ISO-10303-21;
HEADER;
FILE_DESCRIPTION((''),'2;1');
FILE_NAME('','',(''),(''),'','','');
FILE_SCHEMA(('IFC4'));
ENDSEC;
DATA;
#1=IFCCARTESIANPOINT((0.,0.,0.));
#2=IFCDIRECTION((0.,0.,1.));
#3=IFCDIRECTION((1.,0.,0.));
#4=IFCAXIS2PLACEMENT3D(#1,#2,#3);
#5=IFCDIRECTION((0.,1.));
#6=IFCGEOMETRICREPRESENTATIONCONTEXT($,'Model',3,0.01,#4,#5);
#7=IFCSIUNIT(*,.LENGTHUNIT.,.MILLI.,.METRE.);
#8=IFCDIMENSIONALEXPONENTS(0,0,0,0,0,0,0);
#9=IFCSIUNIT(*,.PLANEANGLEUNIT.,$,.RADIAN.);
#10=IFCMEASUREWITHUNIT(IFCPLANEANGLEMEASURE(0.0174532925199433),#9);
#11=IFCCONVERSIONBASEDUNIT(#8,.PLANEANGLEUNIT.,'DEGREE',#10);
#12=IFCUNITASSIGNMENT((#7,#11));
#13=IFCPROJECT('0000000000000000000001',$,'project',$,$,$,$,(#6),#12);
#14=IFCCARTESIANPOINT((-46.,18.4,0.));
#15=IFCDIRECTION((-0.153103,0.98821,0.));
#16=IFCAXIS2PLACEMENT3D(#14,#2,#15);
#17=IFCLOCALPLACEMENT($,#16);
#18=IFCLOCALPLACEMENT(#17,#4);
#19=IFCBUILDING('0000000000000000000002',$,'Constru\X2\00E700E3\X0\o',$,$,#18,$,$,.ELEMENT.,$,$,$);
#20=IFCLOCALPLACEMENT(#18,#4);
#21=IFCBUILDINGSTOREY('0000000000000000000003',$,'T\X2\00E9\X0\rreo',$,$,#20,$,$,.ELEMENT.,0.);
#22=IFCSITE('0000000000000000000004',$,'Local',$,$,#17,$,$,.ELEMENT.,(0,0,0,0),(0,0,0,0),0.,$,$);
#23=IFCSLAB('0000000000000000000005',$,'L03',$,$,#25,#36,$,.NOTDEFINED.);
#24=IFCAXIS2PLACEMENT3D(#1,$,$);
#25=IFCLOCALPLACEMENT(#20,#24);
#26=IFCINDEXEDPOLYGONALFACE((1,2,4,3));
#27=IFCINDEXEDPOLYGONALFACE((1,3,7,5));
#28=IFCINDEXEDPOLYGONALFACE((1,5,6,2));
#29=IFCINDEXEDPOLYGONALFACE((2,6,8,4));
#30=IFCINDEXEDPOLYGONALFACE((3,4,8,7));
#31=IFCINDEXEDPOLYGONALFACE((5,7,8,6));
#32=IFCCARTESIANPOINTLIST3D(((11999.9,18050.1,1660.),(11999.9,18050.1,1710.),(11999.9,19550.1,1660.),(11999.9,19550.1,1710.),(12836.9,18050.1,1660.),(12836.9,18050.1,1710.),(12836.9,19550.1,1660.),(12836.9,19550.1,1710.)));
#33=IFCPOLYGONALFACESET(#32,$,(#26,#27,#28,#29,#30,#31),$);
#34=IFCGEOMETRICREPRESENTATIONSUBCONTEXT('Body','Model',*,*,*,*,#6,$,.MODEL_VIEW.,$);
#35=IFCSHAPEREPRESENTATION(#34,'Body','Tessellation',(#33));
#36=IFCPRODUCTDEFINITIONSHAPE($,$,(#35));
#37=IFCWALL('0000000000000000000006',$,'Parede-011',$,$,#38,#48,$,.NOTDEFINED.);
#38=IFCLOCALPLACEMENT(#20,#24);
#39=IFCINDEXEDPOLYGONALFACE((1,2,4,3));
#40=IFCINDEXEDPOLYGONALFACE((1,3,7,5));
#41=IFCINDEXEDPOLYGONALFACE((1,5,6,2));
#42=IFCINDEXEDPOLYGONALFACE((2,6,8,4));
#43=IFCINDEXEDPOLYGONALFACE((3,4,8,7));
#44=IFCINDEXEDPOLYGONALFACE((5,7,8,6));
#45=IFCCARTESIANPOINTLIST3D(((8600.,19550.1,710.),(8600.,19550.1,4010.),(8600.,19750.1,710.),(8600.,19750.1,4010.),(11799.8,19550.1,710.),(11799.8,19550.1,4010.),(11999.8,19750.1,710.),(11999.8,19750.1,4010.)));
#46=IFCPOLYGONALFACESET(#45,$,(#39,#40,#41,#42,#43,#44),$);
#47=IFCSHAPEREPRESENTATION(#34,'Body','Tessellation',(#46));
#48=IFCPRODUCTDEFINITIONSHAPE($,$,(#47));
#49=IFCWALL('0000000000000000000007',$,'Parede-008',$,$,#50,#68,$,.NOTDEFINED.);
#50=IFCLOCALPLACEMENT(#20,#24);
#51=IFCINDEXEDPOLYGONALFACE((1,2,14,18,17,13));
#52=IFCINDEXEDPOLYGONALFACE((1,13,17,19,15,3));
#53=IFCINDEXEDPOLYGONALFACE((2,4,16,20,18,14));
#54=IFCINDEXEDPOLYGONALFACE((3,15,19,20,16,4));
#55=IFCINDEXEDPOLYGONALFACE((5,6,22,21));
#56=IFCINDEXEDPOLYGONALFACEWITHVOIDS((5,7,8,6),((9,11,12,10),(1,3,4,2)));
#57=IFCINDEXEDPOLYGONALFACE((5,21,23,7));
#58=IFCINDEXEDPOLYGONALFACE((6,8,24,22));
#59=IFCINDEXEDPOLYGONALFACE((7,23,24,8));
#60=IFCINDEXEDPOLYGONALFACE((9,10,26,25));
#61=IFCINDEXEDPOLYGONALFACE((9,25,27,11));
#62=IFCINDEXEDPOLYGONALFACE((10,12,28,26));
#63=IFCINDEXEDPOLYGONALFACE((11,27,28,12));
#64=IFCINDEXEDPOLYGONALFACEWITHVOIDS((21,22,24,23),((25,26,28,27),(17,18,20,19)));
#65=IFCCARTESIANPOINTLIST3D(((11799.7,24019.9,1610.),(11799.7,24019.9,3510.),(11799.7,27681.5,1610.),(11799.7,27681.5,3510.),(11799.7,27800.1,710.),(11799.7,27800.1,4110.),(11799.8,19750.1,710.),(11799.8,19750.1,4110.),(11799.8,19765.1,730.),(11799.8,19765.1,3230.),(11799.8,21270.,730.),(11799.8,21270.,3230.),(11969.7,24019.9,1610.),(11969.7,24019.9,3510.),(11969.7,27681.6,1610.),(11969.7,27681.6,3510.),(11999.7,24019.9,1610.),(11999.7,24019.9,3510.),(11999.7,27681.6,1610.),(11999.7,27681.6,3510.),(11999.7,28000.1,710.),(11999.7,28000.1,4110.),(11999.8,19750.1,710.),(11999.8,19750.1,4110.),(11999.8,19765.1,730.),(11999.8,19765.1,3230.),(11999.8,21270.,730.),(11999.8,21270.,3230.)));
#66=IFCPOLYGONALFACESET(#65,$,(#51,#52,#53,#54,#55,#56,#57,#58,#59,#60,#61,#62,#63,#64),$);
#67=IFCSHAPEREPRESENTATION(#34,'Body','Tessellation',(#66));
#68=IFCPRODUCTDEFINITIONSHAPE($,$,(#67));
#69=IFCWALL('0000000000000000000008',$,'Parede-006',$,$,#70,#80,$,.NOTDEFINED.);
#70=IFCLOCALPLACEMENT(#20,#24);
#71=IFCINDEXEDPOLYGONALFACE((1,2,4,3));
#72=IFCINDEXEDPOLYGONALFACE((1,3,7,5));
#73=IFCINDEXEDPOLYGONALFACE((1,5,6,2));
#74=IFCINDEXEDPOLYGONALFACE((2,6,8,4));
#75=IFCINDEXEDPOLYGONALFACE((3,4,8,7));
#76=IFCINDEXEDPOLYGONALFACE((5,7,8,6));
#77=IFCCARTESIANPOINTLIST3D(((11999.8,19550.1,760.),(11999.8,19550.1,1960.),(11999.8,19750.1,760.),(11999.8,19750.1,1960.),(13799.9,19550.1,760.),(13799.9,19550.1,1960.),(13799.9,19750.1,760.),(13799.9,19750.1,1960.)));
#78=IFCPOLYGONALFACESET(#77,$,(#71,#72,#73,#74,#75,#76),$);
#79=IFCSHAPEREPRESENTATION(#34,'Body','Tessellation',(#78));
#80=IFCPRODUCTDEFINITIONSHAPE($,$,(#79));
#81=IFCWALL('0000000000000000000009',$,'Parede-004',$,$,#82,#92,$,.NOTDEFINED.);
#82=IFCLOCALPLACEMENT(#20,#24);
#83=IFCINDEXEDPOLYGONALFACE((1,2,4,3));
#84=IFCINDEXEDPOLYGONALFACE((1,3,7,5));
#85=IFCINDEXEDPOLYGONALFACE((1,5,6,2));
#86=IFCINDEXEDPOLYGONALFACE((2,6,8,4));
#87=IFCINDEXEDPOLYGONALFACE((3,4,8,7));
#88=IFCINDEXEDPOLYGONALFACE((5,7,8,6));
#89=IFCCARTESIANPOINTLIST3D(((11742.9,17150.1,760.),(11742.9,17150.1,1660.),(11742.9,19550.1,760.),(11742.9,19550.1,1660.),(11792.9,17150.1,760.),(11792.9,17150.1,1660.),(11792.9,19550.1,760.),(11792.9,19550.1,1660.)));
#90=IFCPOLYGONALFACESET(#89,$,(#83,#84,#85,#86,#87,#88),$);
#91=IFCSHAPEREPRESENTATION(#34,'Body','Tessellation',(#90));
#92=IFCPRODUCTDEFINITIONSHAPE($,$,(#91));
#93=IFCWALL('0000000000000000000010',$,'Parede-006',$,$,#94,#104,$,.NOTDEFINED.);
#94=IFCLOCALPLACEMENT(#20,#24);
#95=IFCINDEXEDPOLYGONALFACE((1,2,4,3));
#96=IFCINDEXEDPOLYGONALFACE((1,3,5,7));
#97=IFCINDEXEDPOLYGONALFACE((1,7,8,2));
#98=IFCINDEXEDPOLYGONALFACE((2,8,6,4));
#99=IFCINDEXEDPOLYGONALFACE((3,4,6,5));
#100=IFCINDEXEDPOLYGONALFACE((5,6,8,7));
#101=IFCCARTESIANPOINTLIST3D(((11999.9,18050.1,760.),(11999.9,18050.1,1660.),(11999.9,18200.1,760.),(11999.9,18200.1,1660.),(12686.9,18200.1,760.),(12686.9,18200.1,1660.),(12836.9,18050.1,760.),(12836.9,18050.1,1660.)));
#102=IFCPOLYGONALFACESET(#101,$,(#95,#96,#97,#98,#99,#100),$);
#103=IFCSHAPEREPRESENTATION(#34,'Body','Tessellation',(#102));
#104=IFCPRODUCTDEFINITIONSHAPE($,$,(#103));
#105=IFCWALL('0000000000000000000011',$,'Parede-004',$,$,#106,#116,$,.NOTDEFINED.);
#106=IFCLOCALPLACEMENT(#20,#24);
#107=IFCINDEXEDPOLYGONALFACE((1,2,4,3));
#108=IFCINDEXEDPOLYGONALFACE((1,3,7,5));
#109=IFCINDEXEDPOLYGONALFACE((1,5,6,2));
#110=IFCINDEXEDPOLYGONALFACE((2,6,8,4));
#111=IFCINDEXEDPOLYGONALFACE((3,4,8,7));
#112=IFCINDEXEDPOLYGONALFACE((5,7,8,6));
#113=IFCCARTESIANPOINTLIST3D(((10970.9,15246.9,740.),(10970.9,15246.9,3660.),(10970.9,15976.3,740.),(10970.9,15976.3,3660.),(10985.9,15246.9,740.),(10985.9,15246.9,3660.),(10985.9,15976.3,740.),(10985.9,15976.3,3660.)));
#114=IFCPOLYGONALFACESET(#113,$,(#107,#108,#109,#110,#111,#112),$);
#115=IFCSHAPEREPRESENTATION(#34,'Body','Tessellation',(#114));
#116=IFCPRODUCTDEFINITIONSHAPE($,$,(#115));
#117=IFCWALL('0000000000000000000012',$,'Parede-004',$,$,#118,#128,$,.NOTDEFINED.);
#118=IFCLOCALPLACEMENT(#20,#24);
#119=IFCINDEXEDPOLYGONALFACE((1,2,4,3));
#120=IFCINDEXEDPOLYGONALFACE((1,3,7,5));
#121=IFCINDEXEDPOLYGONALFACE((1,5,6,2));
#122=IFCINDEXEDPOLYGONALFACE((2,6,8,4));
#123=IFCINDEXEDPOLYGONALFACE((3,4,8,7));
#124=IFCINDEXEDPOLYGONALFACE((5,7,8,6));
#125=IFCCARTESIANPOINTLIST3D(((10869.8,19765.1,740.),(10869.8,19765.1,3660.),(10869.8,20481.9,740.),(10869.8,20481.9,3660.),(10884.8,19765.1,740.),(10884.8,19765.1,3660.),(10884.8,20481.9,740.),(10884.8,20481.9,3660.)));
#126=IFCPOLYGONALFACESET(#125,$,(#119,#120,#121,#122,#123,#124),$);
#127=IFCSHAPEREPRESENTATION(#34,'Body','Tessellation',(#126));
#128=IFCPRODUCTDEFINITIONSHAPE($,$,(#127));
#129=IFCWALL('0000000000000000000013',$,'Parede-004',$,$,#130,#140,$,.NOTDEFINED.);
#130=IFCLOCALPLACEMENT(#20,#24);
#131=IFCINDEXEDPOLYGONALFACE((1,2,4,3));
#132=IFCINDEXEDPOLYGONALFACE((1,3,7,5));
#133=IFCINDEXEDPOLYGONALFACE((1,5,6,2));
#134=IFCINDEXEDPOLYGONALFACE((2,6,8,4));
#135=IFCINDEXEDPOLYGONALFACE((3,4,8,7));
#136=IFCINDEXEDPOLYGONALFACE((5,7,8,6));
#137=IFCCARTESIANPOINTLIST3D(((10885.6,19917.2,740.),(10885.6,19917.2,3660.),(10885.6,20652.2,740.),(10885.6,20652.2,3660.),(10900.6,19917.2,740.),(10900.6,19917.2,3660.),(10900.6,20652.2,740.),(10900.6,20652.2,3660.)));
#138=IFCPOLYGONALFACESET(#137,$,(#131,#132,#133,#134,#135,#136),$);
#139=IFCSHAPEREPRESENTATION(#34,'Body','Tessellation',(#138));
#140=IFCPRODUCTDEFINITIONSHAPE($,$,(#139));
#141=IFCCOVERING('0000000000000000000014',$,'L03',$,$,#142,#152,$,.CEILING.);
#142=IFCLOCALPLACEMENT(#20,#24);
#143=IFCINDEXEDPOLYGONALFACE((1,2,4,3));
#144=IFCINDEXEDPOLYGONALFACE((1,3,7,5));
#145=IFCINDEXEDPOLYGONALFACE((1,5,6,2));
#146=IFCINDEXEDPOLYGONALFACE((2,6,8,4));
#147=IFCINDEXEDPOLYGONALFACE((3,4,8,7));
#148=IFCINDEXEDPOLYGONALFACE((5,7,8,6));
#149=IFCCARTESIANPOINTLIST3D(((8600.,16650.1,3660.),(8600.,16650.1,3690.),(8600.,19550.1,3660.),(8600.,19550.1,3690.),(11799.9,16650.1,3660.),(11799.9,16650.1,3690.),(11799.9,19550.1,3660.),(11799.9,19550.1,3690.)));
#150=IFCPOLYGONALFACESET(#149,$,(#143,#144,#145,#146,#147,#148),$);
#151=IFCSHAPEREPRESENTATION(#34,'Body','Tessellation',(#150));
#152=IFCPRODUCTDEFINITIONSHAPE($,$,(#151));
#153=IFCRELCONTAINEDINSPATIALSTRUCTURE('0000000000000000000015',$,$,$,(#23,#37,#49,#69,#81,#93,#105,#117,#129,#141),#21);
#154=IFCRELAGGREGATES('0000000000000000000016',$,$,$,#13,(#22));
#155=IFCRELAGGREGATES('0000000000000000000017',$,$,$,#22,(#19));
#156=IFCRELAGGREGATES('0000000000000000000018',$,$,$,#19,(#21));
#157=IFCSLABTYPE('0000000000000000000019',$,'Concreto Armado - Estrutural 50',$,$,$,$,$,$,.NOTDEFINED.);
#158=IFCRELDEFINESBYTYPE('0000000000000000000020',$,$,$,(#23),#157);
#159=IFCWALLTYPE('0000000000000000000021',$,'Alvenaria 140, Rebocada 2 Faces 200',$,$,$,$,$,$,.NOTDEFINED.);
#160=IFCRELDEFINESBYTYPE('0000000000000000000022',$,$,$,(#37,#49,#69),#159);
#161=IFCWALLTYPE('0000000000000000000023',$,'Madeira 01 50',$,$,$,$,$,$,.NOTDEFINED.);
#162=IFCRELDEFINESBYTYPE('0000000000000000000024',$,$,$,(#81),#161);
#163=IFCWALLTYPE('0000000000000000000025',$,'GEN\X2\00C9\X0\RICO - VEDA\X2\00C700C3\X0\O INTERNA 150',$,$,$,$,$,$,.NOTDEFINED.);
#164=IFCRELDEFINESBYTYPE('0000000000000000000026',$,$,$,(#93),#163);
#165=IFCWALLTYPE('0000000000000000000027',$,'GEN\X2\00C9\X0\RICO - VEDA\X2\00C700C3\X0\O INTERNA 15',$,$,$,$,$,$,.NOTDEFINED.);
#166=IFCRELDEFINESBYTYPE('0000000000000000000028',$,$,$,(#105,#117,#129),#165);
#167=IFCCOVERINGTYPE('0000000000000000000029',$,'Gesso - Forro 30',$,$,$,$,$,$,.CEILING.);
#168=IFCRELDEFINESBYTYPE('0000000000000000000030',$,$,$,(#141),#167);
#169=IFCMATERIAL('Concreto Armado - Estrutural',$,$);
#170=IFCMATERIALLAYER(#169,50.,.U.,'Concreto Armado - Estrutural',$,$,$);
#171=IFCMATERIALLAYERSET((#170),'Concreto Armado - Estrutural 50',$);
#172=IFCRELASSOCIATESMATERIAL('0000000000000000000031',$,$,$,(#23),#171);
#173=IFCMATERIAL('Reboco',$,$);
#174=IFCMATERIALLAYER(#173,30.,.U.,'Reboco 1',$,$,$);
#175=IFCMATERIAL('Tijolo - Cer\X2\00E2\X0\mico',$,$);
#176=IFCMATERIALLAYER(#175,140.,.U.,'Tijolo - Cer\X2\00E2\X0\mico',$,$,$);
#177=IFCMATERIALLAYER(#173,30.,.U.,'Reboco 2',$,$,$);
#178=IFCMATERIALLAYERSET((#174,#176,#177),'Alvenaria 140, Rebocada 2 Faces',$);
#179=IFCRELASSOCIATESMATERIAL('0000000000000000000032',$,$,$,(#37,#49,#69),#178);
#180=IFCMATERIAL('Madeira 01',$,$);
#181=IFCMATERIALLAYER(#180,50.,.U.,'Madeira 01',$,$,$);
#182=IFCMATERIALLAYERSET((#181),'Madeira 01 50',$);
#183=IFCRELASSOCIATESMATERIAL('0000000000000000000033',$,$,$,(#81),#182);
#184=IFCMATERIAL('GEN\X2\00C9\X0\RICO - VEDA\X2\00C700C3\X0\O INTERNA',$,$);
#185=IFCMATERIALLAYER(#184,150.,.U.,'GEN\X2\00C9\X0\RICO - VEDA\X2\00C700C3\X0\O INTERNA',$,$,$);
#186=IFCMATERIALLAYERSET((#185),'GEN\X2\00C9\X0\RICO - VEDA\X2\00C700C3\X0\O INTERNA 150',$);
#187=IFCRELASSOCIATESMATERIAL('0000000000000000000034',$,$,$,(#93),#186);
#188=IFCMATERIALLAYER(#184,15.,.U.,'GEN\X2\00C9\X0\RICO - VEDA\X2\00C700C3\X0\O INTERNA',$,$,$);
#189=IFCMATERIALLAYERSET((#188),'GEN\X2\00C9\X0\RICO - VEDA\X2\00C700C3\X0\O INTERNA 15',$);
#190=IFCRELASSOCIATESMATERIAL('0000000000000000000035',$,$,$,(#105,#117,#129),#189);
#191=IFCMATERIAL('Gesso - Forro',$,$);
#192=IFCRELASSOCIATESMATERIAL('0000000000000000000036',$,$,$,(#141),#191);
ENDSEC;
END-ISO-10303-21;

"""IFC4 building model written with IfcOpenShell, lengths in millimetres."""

from ifc_helpers import new_model, entity, si_unit, converted_unit, direction, frame, origin_with_axes, origin_2d_with_axis, place, context, subcontext, project, spatial, line, indexed_curve, rectangle, outline, extrude, material, layer, layer_set, layer_usage, type_object, element, save


model = new_model("IFC4")

# Units and contexts
model_context = context("Model", 3, precision=0.01, world=origin_with_axes(), true_north=direction((0.0, 1.0)))
body_context = subcontext(model_context, "Body", "Model", "MODEL_VIEW")
ifc_project = project(units=[si_unit("LENGTHUNIT", "METRE", prefix="MILLI"), converted_unit("PLANEANGLEUNIT", "DEGREE", entity("IfcPlaneAngleMeasure", 0.0174532925199433), si_unit("PLANEANGLEUNIT", "RADIAN"), dimensions=[0, 0, 0, 0, 0, 0, 0])], contexts=[model_context])

# Site, building, storey
site_placement = place(None, frame((-46.0, 18.4, 0.0), z_axis=(0.0, 0.0, 1.0), x_axis=(-0.153103, 0.98821, 0.0)))
site = spatial("IfcSite", under=ifc_project, at=site_placement, Name="Local", CompositionType="ELEMENT", RefLatitude=(0, 0, 0, 0), RefLongitude=(0, 0, 0, 0), RefElevation=0.0)
building_placement = place(site_placement, origin_with_axes())
building = spatial("IfcBuilding", under=site, at=building_placement, Name="Construção", CompositionType="ELEMENT")
storey_placement = place(building_placement, origin_with_axes())
storey = spatial("IfcBuildingStorey", under=building, at=storey_placement, Name="Térreo", CompositionType="ELEMENT", Elevation=0.0)

# Slab
ifc_material_1 = material(Name="Concreto Armado - Estrutural")
ifc_layer_1 = layer(ifc_material_1, 50.0, ventilated="UNKNOWN", Name="Concreto Armado - Estrutural")
ifc_layer_set_1 = layer_set([ifc_layer_1], Name="Concreto Armado - Estrutural 50")
ifc_layer_usage_1 = layer_usage(ifc_layer_set_1, "AXIS3", "NEGATIVE", 50.0)
slab_type = type_object("IfcSlabType", Name="Concreto Armado - Estrutural 50", PredefinedType="NOTDEFINED")
slab_placement = place(storey_placement, frame((11999.9, 18050.1, 1710.0), z_axis=(0.0, 0.0, 1.0), x_axis=(1.0, 0.0, 0.0)))
element("IfcSlab", 1, at=slab_placement, inside=storey, type_object=slab_type, material=ifc_layer_usage_1, Name="L03", PredefinedType="NOTDEFINED", context=body_context, shape_type="SweptSolid", body=[
    extrude(outline(indexed_curve([(0.0, 0.0), (837.1, 0.0), (837.1, 1500.0), (0.0, 1500.0)], segments=[line(1, 2, 3, 4, 1)])), frame((0.0, 0.0, -50.0), z_axis=(0.0, 0.0, 1.0), x_axis=(1.0, 0.0, 0.0)), (0.0, 0.0, 1.0), 50.0),
])

# Wall
ifc_material_2 = material(Name="Reboco")
ifc_layer_2 = layer(ifc_material_2, 30.0, ventilated="UNKNOWN", Name="Reboco 1")
ifc_material_3 = material(Name="Tijolo - Cerâmico")
ifc_layer_3 = layer(ifc_material_3, 140.0, ventilated="UNKNOWN", Name="Tijolo - Cerâmico")
ifc_layer_4 = layer(ifc_material_2, 30.0, ventilated="UNKNOWN", Name="Reboco 2")
ifc_layer_set_2 = layer_set([ifc_layer_2, ifc_layer_3, ifc_layer_4], Name="Alvenaria 140, Rebocada 2 Faces")
ifc_layer_usage_2 = layer_usage(ifc_layer_set_2, "AXIS2", "POSITIVE", 0.0)
wall_type_1 = type_object("IfcWallType", Name="Alvenaria 140, Rebocada 2 Faces 200", PredefinedType="NOTDEFINED")
wall_1_placement = place(storey_placement, frame((11999.8, 19750.1, 710.0), z_axis=(0.0, 0.0, 1.0), x_axis=(-1.0, 0.0, 0.0)))
element("IfcWall", 2, at=wall_1_placement, inside=storey, type_object=wall_type_1, material=ifc_layer_usage_2, Name="Parede-011", PredefinedType="NOTDEFINED", context=body_context, shape_type="SweptSolid", body=[
    extrude(outline(indexed_curve([(0.0, 0.0), (3399.9, 0.0), (3399.9, 200.0), (200.0, 200.0)], segments=[line(1, 2, 3, 4, 1)])), origin_with_axes(), (0.0, 0.0, 1.0), 3300.0),
])

# Wall, openings
ifc_layer_usage_3 = layer_usage(ifc_layer_set_2, "AXIS2", "POSITIVE", 0.0)
wall_2_placement = place(storey_placement, frame((11999.8, 19750.1, 710.0), z_axis=(0.0, 0.0, 1.0), x_axis=(-0.000019, 1.0, 0.0)))
wall_2 = element("IfcWall", 3, at=wall_2_placement, inside=storey, type_object=wall_type_1, material=ifc_layer_usage_3, Name="Parede-008", PredefinedType="NOTDEFINED", context=body_context, shape_type="SweptSolid", body=[
    extrude(outline(indexed_curve([(0.0, 0.0), (8250.0, 0.0), (8050.0, 200.0), (0.0, 200.0)], segments=[line(1, 2, 3, 4, 1)])), origin_with_axes(), (0.0, 0.0, 1.0), 3400.0),
])
opening_1_placement = place(wall_2_placement, frame((6100.6, 0.0, 900.0), z_axis=(0.0, 0.0, 1.0), x_axis=(1.0, 0.0, 0.0)))
element("IfcOpeningElement", 4, at=opening_1_placement, cuts=wall_2, context=body_context, shape_type="SweptSolid", body=[
    extrude(rectangle(XDim=3661.7, YDim=1900.0, at=origin_2d_with_axis()), frame((0.0, 30.0, 950.0), z_axis=(0.0, -1.0, 0.0), x_axis=(-1.0, 0.0, 0.0)), (0.0, 0.0, -1.0), 370.0),
    extrude(rectangle(XDim=3661.7, YDim=1900.0, at=origin_2d_with_axis()), frame((0.0, 30.0, 950.0), z_axis=(0.0, 1.0, 0.0), x_axis=(-1.0, 0.0, 0.0)), (0.0, 0.0, -1.0), 230.0),
])
opening_2_placement = place(wall_2_placement, frame((767.5, 0.0, 20.0), z_axis=(0.0, 0.0, 1.0), x_axis=(1.0, 0.0, 0.0)))
element("IfcOpeningElement", 5, at=opening_2_placement, cuts=wall_2, context=body_context, shape_type="SweptSolid", body=[
    extrude(rectangle(XDim=1505.0, YDim=2500.0, at=origin_2d_with_axis()), frame((0.0, 200.0, 1250.0), z_axis=(0.0, 1.0, 0.0), x_axis=(1.0, 0.0, 0.0)), (0.0, 0.0, -1.0), 600.0),
])

# Walls
ifc_layer_usage_4 = layer_usage(ifc_layer_set_2, "AXIS2", "NEGATIVE", 0.0)
wall_3_placement = place(storey_placement, frame((11999.8, 19750.1, 760.0), z_axis=(0.0, 0.0, 1.0), x_axis=(1.0, 0.000002, 0.0)))
element("IfcWall", 6, at=wall_3_placement, inside=storey, type_object=wall_type_1, material=ifc_layer_usage_4, Name="Parede-006", PredefinedType="NOTDEFINED", context=body_context, shape_type="SweptSolid", body=[
    extrude(outline(indexed_curve([(0.0, -200.0), (1800.1, -200.0), (1800.1, 0.0), (0.0, 0.0)], segments=[line(1, 2, 3, 4, 1)])), origin_with_axes(), (0.0, 0.0, 1.0), 1200.0),
])
ifc_material_4 = material(Name="Madeira 01")
ifc_layer_5 = layer(ifc_material_4, 50.0, ventilated="UNKNOWN", Name="Madeira 01")
ifc_layer_set_3 = layer_set([ifc_layer_5], Name="Madeira 01 50")
ifc_layer_usage_5 = layer_usage(ifc_layer_set_3, "AXIS2", "POSITIVE", -50.0)
wall_type_2 = type_object("IfcWallType", Name="Madeira 01 50", PredefinedType="NOTDEFINED")
wall_4_placement = place(storey_placement, frame((11742.9, 17150.1, 760.0), z_axis=(0.0, 0.0, 1.0), x_axis=(-0.000006, 1.0, 0.0)))
element("IfcWall", 7, at=wall_4_placement, inside=storey, type_object=wall_type_2, material=ifc_layer_usage_5, Name="Parede-004", PredefinedType="NOTDEFINED", context=body_context, shape_type="SweptSolid", body=[
    extrude(outline(indexed_curve([(0.0, -50.0), (2400.0, -50.0), (2400.0, 0.0), (0.0, 0.0)], segments=[line(1, 2, 3, 4, 1)])), origin_with_axes(), (0.0, 0.0, 1.0), 900.0),
])
ifc_material_5 = material(Name="GENÉRICO - VEDAÇÃO INTERNA")
ifc_layer_6 = layer(ifc_material_5, 150.0, ventilated="UNKNOWN", Name="GENÉRICO - VEDAÇÃO INTERNA")
ifc_layer_set_4 = layer_set([ifc_layer_6], Name="GENÉRICO - VEDAÇÃO INTERNA 150")
ifc_layer_usage_6 = layer_usage(ifc_layer_set_4, "AXIS2", "POSITIVE", 0.0)
wall_type_3 = type_object("IfcWallType", Name="GENÉRICO - VEDAÇÃO INTERNA 150", PredefinedType="NOTDEFINED")
wall_5_placement = place(storey_placement, frame((11999.9, 18050.1, 760.0), z_axis=(0.0, 0.0, 1.0), x_axis=(1.0, 0.000015, 0.0)))
element("IfcWall", 8, at=wall_5_placement, inside=storey, type_object=wall_type_3, material=ifc_layer_usage_6, Name="Parede-006", PredefinedType="NOTDEFINED", context=body_context, shape_type="SweptSolid", body=[
    extrude(outline(indexed_curve([(0.0, 0.0), (837.1, 0.0), (687.1, 150.0), (0.0, 150.0)], segments=[line(1, 2, 3, 4, 1)])), origin_with_axes(), (0.0, 0.0, 1.0), 900.0),
])
ifc_layer_7 = layer(ifc_material_5, 15.0, ventilated="UNKNOWN", Name="GENÉRICO - VEDAÇÃO INTERNA")
ifc_layer_set_5 = layer_set([ifc_layer_7], Name="GENÉRICO - VEDAÇÃO INTERNA 15")
ifc_layer_usage_7 = layer_usage(ifc_layer_set_5, "AXIS2", "POSITIVE", -15.0)
wall_type_4 = type_object("IfcWallType", Name="GENÉRICO - VEDAÇÃO INTERNA 15", PredefinedType="NOTDEFINED")
wall_6_placement = place(storey_placement, frame((10970.9, 15246.9, 740.0), z_axis=(0.0, 0.0, 1.0), x_axis=(0.000034, 1.0, 0.0)))
element("IfcWall", 9, at=wall_6_placement, inside=storey, type_object=wall_type_4, material=ifc_layer_usage_7, Name="Parede-004", PredefinedType="NOTDEFINED", context=body_context, shape_type="SweptSolid", body=[
    extrude(outline(indexed_curve([(0.0, -15.0), (729.3, -15.0), (729.3, 0.0), (0.0, 0.0)], segments=[line(1, 2, 3, 4, 1)])), origin_with_axes(), (0.0, 0.0, 1.0), 2920.0),
])
ifc_layer_usage_8 = layer_usage(ifc_layer_set_5, "AXIS2", "NEGATIVE", 15.0)
wall_7_placement = place(storey_placement, frame((10869.8, 20481.9, 740.0), z_axis=(0.0, 0.0, 1.0), x_axis=(0.0, -1.0, 0.0)))
element("IfcWall", 10, at=wall_7_placement, inside=storey, type_object=wall_type_4, material=ifc_layer_usage_8, Name="Parede-004", PredefinedType="NOTDEFINED", context=body_context, shape_type="SweptSolid", body=[
    extrude(outline(indexed_curve([(0.0, 0.0), (716.8, 0.0), (716.8, 15.0), (0.0, 15.0)], segments=[line(1, 2, 3, 4, 1)])), origin_with_axes(), (0.0, 0.0, 1.0), 2920.0),
])
ifc_layer_usage_9 = layer_usage(ifc_layer_set_5, "AXIS2", "NEGATIVE", 15.0)
wall_8_placement = place(storey_placement, frame((10885.6, 20652.2, 740.0), z_axis=(0.0, 0.0, 1.0), x_axis=(0.0, -1.0, 0.0)))
element("IfcWall", 11, at=wall_8_placement, inside=storey, type_object=wall_type_4, material=ifc_layer_usage_9, Name="Parede-004", PredefinedType="NOTDEFINED", context=body_context, shape_type="SweptSolid", body=[
    extrude(outline(indexed_curve([(0.0, 0.0), (735.0, 0.0), (735.0, 15.0), (0.0, 15.0)], segments=[line(1, 2, 3, 4, 1)])), origin_with_axes(), (0.0, 0.0, 1.0), 2920.0),
])

# Covering
ifc_material_6 = material(Name="Gesso - Forro")
covering_type = type_object("IfcCoveringType", Name="Gesso - Forro 30", PredefinedType="CEILING")
covering_placement = place(storey_placement, frame((8600.0, 16650.1, 3690.0), z_axis=(0.0, 0.0, 1.0), x_axis=(1.0, 0.0, 0.0)))
element("IfcCovering", 12, at=covering_placement, inside=storey, type_object=covering_type, material=ifc_material_6, Name="L03", PredefinedType="CEILING", context=body_context, shape_type="SweptSolid", body=[
    extrude(outline(indexed_curve([(0.0, 0.0), (3199.9, 0.0), (3199.9, 2900.0), (0.0, 2900.0)], segments=[line(1, 2, 3, 4, 1)])), frame((0.0, 0.0, -30.0), z_axis=(0.0, 0.0, 1.0), x_axis=(1.0, 0.0, 0.0)), (0.0, 0.0, 1.0), 30.0),
])

save(model, "model.ifc")
